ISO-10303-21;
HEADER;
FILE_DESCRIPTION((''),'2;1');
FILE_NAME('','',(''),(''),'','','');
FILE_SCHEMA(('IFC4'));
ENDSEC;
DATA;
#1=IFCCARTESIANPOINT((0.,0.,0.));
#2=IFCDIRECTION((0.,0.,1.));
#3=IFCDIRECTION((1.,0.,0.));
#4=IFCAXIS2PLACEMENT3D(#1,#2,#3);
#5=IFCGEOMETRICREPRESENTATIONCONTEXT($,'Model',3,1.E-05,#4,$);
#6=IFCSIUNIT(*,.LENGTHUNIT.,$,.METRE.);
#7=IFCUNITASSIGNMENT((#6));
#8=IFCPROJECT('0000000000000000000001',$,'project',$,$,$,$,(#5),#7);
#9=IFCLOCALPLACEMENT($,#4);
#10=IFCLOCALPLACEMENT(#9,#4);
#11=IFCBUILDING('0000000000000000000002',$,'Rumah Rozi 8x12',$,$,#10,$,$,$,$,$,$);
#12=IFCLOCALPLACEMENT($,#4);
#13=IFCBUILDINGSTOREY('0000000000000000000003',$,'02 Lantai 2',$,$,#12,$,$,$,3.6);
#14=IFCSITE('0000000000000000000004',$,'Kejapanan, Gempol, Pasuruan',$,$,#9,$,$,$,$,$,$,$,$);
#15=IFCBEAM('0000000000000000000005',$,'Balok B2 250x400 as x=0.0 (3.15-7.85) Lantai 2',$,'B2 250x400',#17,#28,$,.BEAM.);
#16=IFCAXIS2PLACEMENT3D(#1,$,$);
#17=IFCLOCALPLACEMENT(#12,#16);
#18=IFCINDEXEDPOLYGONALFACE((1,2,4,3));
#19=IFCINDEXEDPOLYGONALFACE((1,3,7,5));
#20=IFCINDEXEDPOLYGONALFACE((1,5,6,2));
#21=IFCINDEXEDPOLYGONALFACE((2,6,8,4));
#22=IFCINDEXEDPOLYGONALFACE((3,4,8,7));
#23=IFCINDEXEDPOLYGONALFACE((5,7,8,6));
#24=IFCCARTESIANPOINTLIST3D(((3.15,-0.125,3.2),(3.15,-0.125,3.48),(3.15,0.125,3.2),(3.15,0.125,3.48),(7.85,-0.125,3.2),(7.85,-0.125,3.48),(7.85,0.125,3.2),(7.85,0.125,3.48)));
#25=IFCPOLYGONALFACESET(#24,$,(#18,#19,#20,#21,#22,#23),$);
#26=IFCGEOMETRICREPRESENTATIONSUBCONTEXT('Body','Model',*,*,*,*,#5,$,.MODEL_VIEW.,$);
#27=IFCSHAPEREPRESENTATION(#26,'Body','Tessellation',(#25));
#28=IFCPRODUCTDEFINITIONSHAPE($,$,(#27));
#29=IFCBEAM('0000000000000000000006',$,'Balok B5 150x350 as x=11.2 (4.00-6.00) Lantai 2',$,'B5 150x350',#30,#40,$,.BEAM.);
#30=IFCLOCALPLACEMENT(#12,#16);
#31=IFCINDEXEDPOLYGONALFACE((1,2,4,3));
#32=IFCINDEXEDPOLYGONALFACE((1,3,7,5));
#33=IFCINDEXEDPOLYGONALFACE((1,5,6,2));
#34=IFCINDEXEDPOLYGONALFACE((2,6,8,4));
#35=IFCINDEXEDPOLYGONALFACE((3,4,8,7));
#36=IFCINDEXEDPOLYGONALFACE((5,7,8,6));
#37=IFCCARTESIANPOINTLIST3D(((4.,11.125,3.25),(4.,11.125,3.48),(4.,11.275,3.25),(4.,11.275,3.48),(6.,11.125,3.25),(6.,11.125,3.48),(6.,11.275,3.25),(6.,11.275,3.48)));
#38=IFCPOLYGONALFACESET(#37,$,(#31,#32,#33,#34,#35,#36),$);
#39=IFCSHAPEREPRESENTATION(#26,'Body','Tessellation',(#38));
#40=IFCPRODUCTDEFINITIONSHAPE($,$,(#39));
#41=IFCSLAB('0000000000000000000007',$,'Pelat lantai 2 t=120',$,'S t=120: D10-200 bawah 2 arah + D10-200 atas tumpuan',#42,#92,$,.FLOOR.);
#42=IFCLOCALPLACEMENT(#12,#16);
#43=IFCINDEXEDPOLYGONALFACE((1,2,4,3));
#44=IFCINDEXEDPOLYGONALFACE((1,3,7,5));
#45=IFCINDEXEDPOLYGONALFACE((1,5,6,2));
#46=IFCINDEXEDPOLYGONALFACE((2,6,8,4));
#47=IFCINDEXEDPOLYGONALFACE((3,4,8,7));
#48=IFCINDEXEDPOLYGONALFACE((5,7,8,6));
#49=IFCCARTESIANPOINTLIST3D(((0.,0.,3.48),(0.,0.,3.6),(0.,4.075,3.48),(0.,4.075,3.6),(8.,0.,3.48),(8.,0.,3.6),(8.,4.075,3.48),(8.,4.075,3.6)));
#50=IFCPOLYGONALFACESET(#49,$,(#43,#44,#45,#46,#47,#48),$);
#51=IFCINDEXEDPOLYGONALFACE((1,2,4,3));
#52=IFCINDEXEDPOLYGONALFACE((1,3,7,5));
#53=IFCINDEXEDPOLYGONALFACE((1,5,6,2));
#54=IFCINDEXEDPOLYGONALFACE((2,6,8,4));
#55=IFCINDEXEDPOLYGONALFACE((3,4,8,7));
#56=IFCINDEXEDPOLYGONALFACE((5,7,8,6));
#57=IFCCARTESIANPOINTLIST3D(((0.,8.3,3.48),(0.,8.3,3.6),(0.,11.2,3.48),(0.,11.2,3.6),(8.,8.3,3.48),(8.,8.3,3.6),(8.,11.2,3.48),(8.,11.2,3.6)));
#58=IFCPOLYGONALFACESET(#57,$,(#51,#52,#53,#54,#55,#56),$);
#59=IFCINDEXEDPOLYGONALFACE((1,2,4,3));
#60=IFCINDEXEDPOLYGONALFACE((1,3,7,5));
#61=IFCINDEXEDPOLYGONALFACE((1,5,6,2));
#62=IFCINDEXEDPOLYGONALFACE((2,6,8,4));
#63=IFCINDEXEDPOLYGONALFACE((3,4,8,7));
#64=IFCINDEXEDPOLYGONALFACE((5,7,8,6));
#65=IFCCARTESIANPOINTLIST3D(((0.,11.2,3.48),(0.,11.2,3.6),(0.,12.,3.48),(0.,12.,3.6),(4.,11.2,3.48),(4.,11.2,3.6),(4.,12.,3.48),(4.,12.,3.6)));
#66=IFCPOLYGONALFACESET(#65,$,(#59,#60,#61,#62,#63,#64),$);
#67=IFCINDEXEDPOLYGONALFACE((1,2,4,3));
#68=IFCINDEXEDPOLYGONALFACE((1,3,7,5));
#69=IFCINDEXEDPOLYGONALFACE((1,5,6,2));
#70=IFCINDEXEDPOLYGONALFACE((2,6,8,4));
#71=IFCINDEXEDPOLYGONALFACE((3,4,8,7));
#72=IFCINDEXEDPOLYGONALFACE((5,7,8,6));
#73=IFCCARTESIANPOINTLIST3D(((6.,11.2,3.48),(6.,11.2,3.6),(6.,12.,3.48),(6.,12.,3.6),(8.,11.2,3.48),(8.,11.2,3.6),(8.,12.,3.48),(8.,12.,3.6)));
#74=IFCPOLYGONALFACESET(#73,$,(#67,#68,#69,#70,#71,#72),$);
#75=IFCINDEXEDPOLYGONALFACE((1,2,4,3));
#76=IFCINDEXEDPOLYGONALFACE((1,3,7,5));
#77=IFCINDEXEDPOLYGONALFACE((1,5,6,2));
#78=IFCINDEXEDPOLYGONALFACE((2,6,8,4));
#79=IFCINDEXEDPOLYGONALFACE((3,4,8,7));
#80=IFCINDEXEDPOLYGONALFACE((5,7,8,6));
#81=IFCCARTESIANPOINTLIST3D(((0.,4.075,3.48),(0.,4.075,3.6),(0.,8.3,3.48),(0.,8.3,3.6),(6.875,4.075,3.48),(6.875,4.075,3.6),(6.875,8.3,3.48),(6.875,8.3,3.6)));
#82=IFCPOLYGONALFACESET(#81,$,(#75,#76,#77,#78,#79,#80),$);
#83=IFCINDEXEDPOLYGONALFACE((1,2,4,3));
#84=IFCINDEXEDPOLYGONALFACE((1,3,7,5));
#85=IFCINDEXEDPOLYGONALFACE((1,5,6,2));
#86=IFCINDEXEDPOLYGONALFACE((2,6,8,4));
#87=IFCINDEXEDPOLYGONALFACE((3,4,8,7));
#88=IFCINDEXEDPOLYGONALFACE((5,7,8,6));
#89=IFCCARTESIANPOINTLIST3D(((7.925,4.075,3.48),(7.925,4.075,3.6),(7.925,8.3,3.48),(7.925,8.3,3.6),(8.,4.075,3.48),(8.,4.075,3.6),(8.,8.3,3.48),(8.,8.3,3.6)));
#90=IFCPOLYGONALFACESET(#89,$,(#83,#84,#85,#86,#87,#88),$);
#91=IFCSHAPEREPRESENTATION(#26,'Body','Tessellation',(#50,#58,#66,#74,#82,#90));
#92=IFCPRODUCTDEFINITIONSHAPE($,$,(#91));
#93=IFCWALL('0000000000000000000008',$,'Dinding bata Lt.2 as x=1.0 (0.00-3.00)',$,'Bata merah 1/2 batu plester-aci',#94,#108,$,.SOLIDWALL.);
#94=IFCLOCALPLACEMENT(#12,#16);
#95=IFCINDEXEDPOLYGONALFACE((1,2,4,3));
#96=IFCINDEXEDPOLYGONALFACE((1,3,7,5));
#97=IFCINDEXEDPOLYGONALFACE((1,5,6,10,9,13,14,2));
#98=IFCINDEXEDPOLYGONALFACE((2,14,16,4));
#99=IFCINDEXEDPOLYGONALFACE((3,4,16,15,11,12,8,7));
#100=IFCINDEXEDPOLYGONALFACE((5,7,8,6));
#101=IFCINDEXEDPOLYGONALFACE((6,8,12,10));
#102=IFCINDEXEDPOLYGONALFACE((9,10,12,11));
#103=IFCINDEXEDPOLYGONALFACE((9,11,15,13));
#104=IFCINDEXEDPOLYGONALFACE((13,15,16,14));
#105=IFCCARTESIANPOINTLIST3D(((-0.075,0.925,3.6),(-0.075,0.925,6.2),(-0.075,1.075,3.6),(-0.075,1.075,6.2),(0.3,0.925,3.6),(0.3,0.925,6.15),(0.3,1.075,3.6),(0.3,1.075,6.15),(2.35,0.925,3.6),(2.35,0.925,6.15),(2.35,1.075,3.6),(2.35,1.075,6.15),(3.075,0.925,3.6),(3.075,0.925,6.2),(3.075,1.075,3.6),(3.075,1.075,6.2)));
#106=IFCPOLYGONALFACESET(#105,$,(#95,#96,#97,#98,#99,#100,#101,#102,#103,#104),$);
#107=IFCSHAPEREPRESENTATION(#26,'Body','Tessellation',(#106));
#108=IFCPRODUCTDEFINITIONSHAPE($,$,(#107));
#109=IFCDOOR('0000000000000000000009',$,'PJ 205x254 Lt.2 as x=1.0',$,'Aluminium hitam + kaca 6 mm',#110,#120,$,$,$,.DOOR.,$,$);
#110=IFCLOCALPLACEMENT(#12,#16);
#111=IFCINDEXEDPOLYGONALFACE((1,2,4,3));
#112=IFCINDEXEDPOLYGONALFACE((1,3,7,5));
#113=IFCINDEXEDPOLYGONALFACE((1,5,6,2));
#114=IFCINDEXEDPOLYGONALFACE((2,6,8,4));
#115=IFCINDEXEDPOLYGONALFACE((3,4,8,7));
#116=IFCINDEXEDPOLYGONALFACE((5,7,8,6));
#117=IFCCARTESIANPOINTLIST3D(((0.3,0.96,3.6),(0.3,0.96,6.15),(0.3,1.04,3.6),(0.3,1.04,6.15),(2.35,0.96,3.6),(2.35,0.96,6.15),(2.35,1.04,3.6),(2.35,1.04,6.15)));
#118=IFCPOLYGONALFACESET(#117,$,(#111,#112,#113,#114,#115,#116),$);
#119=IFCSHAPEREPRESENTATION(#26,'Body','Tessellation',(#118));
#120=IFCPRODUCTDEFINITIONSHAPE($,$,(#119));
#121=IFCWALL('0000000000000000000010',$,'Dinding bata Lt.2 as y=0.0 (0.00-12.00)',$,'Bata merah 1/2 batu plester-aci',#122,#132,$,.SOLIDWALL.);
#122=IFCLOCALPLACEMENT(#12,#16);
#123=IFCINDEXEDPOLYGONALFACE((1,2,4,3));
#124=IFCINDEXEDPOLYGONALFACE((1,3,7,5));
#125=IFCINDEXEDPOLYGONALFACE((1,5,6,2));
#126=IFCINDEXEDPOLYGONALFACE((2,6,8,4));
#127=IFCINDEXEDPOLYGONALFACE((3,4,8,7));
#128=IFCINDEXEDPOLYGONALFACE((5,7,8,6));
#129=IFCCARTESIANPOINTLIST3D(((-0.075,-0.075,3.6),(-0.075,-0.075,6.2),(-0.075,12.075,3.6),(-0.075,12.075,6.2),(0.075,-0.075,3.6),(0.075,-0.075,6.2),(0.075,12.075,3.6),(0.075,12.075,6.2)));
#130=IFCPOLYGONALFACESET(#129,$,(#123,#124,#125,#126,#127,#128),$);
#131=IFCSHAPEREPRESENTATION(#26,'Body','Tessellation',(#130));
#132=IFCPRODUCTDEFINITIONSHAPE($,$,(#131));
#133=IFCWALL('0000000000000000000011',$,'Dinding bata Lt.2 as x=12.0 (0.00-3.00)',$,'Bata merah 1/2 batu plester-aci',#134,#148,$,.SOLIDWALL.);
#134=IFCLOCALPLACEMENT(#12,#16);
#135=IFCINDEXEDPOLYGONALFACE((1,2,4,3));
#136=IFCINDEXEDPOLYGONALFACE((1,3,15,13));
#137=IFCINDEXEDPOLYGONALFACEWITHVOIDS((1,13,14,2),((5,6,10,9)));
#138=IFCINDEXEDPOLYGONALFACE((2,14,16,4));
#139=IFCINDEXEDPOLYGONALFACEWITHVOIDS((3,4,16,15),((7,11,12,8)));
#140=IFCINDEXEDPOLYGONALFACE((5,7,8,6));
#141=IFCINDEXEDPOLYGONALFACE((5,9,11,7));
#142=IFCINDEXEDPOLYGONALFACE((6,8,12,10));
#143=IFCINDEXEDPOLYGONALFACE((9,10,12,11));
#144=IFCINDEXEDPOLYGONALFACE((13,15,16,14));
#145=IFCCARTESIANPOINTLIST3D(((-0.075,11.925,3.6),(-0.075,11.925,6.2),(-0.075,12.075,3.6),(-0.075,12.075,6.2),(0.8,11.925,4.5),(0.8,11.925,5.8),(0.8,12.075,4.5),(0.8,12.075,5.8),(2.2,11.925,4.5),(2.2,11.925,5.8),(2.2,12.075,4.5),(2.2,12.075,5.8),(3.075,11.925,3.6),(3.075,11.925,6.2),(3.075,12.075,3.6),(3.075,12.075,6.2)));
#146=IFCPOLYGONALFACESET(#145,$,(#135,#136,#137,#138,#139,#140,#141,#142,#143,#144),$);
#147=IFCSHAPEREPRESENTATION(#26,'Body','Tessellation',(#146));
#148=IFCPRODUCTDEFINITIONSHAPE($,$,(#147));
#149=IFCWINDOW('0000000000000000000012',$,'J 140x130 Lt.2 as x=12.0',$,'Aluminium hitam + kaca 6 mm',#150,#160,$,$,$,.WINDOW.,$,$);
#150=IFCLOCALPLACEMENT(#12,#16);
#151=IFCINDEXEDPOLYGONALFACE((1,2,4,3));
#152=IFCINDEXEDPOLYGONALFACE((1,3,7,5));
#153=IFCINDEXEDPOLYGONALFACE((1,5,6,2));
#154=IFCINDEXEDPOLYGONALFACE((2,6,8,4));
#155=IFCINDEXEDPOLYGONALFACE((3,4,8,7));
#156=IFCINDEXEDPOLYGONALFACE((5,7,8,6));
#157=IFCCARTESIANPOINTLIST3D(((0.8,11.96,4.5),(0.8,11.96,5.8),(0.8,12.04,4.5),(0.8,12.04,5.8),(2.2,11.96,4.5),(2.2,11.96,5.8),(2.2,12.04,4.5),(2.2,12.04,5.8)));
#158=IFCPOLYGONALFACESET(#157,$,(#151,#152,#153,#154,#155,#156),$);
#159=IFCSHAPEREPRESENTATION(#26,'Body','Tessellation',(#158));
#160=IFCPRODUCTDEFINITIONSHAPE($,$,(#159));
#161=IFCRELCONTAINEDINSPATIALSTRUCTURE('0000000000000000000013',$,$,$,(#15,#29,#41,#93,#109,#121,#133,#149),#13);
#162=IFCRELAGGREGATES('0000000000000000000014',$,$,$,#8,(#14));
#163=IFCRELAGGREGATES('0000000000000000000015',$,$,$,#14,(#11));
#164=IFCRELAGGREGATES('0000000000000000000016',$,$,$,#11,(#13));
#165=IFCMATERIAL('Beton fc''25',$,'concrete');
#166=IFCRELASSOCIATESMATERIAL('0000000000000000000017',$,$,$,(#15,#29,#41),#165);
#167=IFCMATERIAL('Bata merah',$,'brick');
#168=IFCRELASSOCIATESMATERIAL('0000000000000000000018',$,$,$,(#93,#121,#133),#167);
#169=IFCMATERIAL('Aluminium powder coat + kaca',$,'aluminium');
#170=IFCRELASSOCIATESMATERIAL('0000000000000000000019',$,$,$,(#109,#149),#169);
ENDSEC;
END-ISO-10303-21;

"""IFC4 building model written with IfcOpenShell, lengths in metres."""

from ifc_helpers import new_model, si_unit, frame, origin_with_axes, place, context, subcontext, project, spatial, line, indexed_curve, outline, extrude, material, element, fill, save


model = new_model("IFC4")

# Units and contexts
model_context = context("Model", 3, precision=1e-05, world=origin_with_axes())
body_context = subcontext(model_context, "Body", "Model", "MODEL_VIEW")
ifc_project = project(units=[si_unit("LENGTHUNIT", "METRE")], contexts=[model_context])

# Site, building, storey
site_placement = place(None, origin_with_axes())
site = spatial("IfcSite", under=ifc_project, at=site_placement, Name="Kejapanan, Gempol, Pasuruan")
building_placement = place(site_placement, origin_with_axes())
building = spatial("IfcBuilding", under=site, at=building_placement, Name="Rumah Rozi 8x12")
storey_placement = place(None, origin_with_axes())
storey = spatial("IfcBuildingStorey", under=building, at=storey_placement, Name="02 Lantai 2", Elevation=3.6)

# Beams
ifc_material_1 = material(Name="Beton fc'25", Category="concrete")
beam_1_placement = place(storey_placement, origin_with_axes())
element("IfcBeam", 1, at=beam_1_placement, inside=storey, material=ifc_material_1, Name="Balok B2 250x400 as x=0.0 (3.15-7.85) Lantai 2", ObjectType="B2 250x400", PredefinedType="BEAM", context=body_context, shape_type="SweptSolid", body=[
    extrude(outline(indexed_curve([(3.15, -0.125), (7.85, -0.125), (7.85, 0.125), (3.15, 0.125)], segments=[line(1, 2, 3, 4, 1)])), frame((0.0, 0.0, 3.2), z_axis=(0.0, 0.0, 1.0), x_axis=(1.0, 0.0, 0.0)), (0.0, 0.0, 1.0), 0.28),
])
beam_2_placement = place(storey_placement, origin_with_axes())
element("IfcBeam", 2, at=beam_2_placement, inside=storey, material=ifc_material_1, Name="Balok B5 150x350 as x=11.2 (4.00-6.00) Lantai 2", ObjectType="B5 150x350", PredefinedType="BEAM", context=body_context, shape_type="SweptSolid", body=[
    extrude(outline(indexed_curve([(4.0, 11.125), (6.0, 11.125), (6.0, 11.275), (4.0, 11.275)], segments=[line(1, 2, 3, 4, 1)])), frame((0.0, 0.0, 3.25), z_axis=(0.0, 0.0, 1.0), x_axis=(1.0, 0.0, 0.0)), (0.0, 0.0, 1.0), 0.23),
])

# Slab
slab_placement = place(storey_placement, origin_with_axes())
element("IfcSlab", 3, at=slab_placement, inside=storey, material=ifc_material_1, Name="Pelat lantai 2 t=120", ObjectType="S t=120: D10-200 bawah 2 arah + D10-200 atas tumpuan", PredefinedType="FLOOR", context=body_context, shape_type="SweptSolid", body=[
    extrude(outline(indexed_curve([(0.0, 0.0), (8.0, 0.0), (8.0, 4.075), (0.0, 4.075)], segments=[line(1, 2, 3, 4, 1)])), frame((0.0, 0.0, 3.48), z_axis=(0.0, 0.0, 1.0), x_axis=(1.0, 0.0, 0.0)), (0.0, 0.0, 1.0), 0.12),
    extrude(outline(indexed_curve([(0.0, 8.3), (8.0, 8.3), (8.0, 11.2), (0.0, 11.2)], segments=[line(1, 2, 3, 4, 1)])), frame((0.0, 0.0, 3.48), z_axis=(0.0, 0.0, 1.0), x_axis=(1.0, 0.0, 0.0)), (0.0, 0.0, 1.0), 0.12),
    extrude(outline(indexed_curve([(0.0, 11.2), (4.0, 11.2), (4.0, 12.0), (0.0, 12.0)], segments=[line(1, 2, 3, 4, 1)])), frame((0.0, 0.0, 3.48), z_axis=(0.0, 0.0, 1.0), x_axis=(1.0, 0.0, 0.0)), (0.0, 0.0, 1.0), 0.12),
    extrude(outline(indexed_curve([(6.0, 11.2), (8.0, 11.2), (8.0, 12.0), (6.0, 12.0)], segments=[line(1, 2, 3, 4, 1)])), frame((0.0, 0.0, 3.48), z_axis=(0.0, 0.0, 1.0), x_axis=(1.0, 0.0, 0.0)), (0.0, 0.0, 1.0), 0.12),
    extrude(outline(indexed_curve([(0.0, 4.075), (6.875, 4.075), (6.875, 8.3), (0.0, 8.3)], segments=[line(1, 2, 3, 4, 1)])), frame((0.0, 0.0, 3.48), z_axis=(0.0, 0.0, 1.0), x_axis=(1.0, 0.0, 0.0)), (0.0, 0.0, 1.0), 0.12),
    extrude(outline(indexed_curve([(7.925, 4.075), (8.0, 4.075), (8.0, 8.3), (7.925, 8.3)], segments=[line(1, 2, 3, 4, 1)])), frame((0.0, 0.0, 3.48), z_axis=(0.0, 0.0, 1.0), x_axis=(1.0, 0.0, 0.0)), (0.0, 0.0, 1.0), 0.12),
])

# Wall, opening, door
ifc_material_2 = material(Name="Bata merah", Category="brick")
wall_1_placement = place(storey_placement, origin_with_axes())
wall_1 = element("IfcWall", 4, at=wall_1_placement, inside=storey, material=ifc_material_2, Name="Dinding bata Lt.2 as x=1.0 (0.00-3.00)", ObjectType="Bata merah 1/2 batu plester-aci", PredefinedType="SOLIDWALL", context=body_context, shape_type="SweptSolid", body=[
    extrude(outline(indexed_curve([(-0.075, 0.925), (3.075, 0.925), (3.075, 1.075), (-0.075, 1.075)], segments=[line(1, 2, 3, 4, 1)])), frame((0.0, 0.0, 3.6), z_axis=(0.0, 0.0, 1.0), x_axis=(1.0, 0.0, 0.0)), (0.0, 0.0, 1.0), 2.6),
])
opening_1_placement = place(wall_1_placement, origin_with_axes())
opening_1 = element("IfcOpeningElement", 5, at=opening_1_placement, cuts=wall_1, context=body_context, shape_type="SweptSolid", body=[
    extrude(outline(indexed_curve([(0.3, 0.915), (2.35, 0.915), (2.35, 1.085), (0.3, 1.085)], segments=[line(1, 2, 3, 4, 1)])), frame((0.0, 0.0, 3.6), z_axis=(0.0, 0.0, 1.0), x_axis=(1.0, 0.0, 0.0)), (0.0, 0.0, 1.0), 2.55),
])
ifc_material_3 = material(Name="Aluminium powder coat + kaca", Category="aluminium")
door_placement = place(storey_placement, origin_with_axes())
door = element("IfcDoor", 6, at=door_placement, inside=storey, material=ifc_material_3, Name="PJ 205x254 Lt.2 as x=1.0", ObjectType="Aluminium hitam + kaca 6 mm", PredefinedType="DOOR", context=body_context, shape_type="SweptSolid", body=[
    extrude(outline(indexed_curve([(0.3, 0.96), (2.35, 0.96), (2.35, 1.04), (0.3, 1.04)], segments=[line(1, 2, 3, 4, 1)])), frame((0.0, 0.0, 3.6), z_axis=(0.0, 0.0, 1.0), x_axis=(1.0, 0.0, 0.0)), (0.0, 0.0, 1.0), 2.55),
])
fill(opening_1, door)

# Wall
wall_2_placement = place(storey_placement, origin_with_axes())
element("IfcWall", 7, at=wall_2_placement, inside=storey, material=ifc_material_2, Name="Dinding bata Lt.2 as y=0.0 (0.00-12.00)", ObjectType="Bata merah 1/2 batu plester-aci", PredefinedType="SOLIDWALL", context=body_context, shape_type="SweptSolid", body=[
    extrude(outline(indexed_curve([(-0.075, -0.075), (0.075, -0.075), (0.075, 12.075), (-0.075, 12.075)], segments=[line(1, 2, 3, 4, 1)])), frame((0.0, 0.0, 3.6), z_axis=(0.0, 0.0, 1.0), x_axis=(1.0, 0.0, 0.0)), (0.0, 0.0, 1.0), 2.6),
])

# Wall, opening, window
wall_3_placement = place(storey_placement, origin_with_axes())
wall_3 = element("IfcWall", 8, at=wall_3_placement, inside=storey, material=ifc_material_2, Name="Dinding bata Lt.2 as x=12.0 (0.00-3.00)", ObjectType="Bata merah 1/2 batu plester-aci", PredefinedType="SOLIDWALL", context=body_context, shape_type="SweptSolid", body=[
    extrude(outline(indexed_curve([(-0.075, 11.925), (3.075, 11.925), (3.075, 12.075), (-0.075, 12.075)], segments=[line(1, 2, 3, 4, 1)])), frame((0.0, 0.0, 3.6), z_axis=(0.0, 0.0, 1.0), x_axis=(1.0, 0.0, 0.0)), (0.0, 0.0, 1.0), 2.6),
])
opening_2_placement = place(wall_3_placement, origin_with_axes())
opening_2 = element("IfcOpeningElement", 9, at=opening_2_placement, cuts=wall_3, context=body_context, shape_type="SweptSolid", body=[
    extrude(outline(indexed_curve([(0.8, 11.915), (2.2, 11.915), (2.2, 12.085), (0.8, 12.085)], segments=[line(1, 2, 3, 4, 1)])), frame((0.0, 0.0, 4.5), z_axis=(0.0, 0.0, 1.0), x_axis=(1.0, 0.0, 0.0)), (0.0, 0.0, 1.0), 1.3),
])
window_placement = place(storey_placement, origin_with_axes())
window = element("IfcWindow", 10, at=window_placement, inside=storey, material=ifc_material_3, Name="J 140x130 Lt.2 as x=12.0", ObjectType="Aluminium hitam + kaca 6 mm", PredefinedType="WINDOW", context=body_context, shape_type="SweptSolid", body=[
    extrude(outline(indexed_curve([(0.8, 11.96), (2.2, 11.96), (2.2, 12.04), (0.8, 12.04)], segments=[line(1, 2, 3, 4, 1)])), frame((0.0, 0.0, 4.5), z_axis=(0.0, 0.0, 1.0), x_axis=(1.0, 0.0, 0.0)), (0.0, 0.0, 1.0), 1.3),
])
fill(opening_2, window)

save(model, "model.ifc")
